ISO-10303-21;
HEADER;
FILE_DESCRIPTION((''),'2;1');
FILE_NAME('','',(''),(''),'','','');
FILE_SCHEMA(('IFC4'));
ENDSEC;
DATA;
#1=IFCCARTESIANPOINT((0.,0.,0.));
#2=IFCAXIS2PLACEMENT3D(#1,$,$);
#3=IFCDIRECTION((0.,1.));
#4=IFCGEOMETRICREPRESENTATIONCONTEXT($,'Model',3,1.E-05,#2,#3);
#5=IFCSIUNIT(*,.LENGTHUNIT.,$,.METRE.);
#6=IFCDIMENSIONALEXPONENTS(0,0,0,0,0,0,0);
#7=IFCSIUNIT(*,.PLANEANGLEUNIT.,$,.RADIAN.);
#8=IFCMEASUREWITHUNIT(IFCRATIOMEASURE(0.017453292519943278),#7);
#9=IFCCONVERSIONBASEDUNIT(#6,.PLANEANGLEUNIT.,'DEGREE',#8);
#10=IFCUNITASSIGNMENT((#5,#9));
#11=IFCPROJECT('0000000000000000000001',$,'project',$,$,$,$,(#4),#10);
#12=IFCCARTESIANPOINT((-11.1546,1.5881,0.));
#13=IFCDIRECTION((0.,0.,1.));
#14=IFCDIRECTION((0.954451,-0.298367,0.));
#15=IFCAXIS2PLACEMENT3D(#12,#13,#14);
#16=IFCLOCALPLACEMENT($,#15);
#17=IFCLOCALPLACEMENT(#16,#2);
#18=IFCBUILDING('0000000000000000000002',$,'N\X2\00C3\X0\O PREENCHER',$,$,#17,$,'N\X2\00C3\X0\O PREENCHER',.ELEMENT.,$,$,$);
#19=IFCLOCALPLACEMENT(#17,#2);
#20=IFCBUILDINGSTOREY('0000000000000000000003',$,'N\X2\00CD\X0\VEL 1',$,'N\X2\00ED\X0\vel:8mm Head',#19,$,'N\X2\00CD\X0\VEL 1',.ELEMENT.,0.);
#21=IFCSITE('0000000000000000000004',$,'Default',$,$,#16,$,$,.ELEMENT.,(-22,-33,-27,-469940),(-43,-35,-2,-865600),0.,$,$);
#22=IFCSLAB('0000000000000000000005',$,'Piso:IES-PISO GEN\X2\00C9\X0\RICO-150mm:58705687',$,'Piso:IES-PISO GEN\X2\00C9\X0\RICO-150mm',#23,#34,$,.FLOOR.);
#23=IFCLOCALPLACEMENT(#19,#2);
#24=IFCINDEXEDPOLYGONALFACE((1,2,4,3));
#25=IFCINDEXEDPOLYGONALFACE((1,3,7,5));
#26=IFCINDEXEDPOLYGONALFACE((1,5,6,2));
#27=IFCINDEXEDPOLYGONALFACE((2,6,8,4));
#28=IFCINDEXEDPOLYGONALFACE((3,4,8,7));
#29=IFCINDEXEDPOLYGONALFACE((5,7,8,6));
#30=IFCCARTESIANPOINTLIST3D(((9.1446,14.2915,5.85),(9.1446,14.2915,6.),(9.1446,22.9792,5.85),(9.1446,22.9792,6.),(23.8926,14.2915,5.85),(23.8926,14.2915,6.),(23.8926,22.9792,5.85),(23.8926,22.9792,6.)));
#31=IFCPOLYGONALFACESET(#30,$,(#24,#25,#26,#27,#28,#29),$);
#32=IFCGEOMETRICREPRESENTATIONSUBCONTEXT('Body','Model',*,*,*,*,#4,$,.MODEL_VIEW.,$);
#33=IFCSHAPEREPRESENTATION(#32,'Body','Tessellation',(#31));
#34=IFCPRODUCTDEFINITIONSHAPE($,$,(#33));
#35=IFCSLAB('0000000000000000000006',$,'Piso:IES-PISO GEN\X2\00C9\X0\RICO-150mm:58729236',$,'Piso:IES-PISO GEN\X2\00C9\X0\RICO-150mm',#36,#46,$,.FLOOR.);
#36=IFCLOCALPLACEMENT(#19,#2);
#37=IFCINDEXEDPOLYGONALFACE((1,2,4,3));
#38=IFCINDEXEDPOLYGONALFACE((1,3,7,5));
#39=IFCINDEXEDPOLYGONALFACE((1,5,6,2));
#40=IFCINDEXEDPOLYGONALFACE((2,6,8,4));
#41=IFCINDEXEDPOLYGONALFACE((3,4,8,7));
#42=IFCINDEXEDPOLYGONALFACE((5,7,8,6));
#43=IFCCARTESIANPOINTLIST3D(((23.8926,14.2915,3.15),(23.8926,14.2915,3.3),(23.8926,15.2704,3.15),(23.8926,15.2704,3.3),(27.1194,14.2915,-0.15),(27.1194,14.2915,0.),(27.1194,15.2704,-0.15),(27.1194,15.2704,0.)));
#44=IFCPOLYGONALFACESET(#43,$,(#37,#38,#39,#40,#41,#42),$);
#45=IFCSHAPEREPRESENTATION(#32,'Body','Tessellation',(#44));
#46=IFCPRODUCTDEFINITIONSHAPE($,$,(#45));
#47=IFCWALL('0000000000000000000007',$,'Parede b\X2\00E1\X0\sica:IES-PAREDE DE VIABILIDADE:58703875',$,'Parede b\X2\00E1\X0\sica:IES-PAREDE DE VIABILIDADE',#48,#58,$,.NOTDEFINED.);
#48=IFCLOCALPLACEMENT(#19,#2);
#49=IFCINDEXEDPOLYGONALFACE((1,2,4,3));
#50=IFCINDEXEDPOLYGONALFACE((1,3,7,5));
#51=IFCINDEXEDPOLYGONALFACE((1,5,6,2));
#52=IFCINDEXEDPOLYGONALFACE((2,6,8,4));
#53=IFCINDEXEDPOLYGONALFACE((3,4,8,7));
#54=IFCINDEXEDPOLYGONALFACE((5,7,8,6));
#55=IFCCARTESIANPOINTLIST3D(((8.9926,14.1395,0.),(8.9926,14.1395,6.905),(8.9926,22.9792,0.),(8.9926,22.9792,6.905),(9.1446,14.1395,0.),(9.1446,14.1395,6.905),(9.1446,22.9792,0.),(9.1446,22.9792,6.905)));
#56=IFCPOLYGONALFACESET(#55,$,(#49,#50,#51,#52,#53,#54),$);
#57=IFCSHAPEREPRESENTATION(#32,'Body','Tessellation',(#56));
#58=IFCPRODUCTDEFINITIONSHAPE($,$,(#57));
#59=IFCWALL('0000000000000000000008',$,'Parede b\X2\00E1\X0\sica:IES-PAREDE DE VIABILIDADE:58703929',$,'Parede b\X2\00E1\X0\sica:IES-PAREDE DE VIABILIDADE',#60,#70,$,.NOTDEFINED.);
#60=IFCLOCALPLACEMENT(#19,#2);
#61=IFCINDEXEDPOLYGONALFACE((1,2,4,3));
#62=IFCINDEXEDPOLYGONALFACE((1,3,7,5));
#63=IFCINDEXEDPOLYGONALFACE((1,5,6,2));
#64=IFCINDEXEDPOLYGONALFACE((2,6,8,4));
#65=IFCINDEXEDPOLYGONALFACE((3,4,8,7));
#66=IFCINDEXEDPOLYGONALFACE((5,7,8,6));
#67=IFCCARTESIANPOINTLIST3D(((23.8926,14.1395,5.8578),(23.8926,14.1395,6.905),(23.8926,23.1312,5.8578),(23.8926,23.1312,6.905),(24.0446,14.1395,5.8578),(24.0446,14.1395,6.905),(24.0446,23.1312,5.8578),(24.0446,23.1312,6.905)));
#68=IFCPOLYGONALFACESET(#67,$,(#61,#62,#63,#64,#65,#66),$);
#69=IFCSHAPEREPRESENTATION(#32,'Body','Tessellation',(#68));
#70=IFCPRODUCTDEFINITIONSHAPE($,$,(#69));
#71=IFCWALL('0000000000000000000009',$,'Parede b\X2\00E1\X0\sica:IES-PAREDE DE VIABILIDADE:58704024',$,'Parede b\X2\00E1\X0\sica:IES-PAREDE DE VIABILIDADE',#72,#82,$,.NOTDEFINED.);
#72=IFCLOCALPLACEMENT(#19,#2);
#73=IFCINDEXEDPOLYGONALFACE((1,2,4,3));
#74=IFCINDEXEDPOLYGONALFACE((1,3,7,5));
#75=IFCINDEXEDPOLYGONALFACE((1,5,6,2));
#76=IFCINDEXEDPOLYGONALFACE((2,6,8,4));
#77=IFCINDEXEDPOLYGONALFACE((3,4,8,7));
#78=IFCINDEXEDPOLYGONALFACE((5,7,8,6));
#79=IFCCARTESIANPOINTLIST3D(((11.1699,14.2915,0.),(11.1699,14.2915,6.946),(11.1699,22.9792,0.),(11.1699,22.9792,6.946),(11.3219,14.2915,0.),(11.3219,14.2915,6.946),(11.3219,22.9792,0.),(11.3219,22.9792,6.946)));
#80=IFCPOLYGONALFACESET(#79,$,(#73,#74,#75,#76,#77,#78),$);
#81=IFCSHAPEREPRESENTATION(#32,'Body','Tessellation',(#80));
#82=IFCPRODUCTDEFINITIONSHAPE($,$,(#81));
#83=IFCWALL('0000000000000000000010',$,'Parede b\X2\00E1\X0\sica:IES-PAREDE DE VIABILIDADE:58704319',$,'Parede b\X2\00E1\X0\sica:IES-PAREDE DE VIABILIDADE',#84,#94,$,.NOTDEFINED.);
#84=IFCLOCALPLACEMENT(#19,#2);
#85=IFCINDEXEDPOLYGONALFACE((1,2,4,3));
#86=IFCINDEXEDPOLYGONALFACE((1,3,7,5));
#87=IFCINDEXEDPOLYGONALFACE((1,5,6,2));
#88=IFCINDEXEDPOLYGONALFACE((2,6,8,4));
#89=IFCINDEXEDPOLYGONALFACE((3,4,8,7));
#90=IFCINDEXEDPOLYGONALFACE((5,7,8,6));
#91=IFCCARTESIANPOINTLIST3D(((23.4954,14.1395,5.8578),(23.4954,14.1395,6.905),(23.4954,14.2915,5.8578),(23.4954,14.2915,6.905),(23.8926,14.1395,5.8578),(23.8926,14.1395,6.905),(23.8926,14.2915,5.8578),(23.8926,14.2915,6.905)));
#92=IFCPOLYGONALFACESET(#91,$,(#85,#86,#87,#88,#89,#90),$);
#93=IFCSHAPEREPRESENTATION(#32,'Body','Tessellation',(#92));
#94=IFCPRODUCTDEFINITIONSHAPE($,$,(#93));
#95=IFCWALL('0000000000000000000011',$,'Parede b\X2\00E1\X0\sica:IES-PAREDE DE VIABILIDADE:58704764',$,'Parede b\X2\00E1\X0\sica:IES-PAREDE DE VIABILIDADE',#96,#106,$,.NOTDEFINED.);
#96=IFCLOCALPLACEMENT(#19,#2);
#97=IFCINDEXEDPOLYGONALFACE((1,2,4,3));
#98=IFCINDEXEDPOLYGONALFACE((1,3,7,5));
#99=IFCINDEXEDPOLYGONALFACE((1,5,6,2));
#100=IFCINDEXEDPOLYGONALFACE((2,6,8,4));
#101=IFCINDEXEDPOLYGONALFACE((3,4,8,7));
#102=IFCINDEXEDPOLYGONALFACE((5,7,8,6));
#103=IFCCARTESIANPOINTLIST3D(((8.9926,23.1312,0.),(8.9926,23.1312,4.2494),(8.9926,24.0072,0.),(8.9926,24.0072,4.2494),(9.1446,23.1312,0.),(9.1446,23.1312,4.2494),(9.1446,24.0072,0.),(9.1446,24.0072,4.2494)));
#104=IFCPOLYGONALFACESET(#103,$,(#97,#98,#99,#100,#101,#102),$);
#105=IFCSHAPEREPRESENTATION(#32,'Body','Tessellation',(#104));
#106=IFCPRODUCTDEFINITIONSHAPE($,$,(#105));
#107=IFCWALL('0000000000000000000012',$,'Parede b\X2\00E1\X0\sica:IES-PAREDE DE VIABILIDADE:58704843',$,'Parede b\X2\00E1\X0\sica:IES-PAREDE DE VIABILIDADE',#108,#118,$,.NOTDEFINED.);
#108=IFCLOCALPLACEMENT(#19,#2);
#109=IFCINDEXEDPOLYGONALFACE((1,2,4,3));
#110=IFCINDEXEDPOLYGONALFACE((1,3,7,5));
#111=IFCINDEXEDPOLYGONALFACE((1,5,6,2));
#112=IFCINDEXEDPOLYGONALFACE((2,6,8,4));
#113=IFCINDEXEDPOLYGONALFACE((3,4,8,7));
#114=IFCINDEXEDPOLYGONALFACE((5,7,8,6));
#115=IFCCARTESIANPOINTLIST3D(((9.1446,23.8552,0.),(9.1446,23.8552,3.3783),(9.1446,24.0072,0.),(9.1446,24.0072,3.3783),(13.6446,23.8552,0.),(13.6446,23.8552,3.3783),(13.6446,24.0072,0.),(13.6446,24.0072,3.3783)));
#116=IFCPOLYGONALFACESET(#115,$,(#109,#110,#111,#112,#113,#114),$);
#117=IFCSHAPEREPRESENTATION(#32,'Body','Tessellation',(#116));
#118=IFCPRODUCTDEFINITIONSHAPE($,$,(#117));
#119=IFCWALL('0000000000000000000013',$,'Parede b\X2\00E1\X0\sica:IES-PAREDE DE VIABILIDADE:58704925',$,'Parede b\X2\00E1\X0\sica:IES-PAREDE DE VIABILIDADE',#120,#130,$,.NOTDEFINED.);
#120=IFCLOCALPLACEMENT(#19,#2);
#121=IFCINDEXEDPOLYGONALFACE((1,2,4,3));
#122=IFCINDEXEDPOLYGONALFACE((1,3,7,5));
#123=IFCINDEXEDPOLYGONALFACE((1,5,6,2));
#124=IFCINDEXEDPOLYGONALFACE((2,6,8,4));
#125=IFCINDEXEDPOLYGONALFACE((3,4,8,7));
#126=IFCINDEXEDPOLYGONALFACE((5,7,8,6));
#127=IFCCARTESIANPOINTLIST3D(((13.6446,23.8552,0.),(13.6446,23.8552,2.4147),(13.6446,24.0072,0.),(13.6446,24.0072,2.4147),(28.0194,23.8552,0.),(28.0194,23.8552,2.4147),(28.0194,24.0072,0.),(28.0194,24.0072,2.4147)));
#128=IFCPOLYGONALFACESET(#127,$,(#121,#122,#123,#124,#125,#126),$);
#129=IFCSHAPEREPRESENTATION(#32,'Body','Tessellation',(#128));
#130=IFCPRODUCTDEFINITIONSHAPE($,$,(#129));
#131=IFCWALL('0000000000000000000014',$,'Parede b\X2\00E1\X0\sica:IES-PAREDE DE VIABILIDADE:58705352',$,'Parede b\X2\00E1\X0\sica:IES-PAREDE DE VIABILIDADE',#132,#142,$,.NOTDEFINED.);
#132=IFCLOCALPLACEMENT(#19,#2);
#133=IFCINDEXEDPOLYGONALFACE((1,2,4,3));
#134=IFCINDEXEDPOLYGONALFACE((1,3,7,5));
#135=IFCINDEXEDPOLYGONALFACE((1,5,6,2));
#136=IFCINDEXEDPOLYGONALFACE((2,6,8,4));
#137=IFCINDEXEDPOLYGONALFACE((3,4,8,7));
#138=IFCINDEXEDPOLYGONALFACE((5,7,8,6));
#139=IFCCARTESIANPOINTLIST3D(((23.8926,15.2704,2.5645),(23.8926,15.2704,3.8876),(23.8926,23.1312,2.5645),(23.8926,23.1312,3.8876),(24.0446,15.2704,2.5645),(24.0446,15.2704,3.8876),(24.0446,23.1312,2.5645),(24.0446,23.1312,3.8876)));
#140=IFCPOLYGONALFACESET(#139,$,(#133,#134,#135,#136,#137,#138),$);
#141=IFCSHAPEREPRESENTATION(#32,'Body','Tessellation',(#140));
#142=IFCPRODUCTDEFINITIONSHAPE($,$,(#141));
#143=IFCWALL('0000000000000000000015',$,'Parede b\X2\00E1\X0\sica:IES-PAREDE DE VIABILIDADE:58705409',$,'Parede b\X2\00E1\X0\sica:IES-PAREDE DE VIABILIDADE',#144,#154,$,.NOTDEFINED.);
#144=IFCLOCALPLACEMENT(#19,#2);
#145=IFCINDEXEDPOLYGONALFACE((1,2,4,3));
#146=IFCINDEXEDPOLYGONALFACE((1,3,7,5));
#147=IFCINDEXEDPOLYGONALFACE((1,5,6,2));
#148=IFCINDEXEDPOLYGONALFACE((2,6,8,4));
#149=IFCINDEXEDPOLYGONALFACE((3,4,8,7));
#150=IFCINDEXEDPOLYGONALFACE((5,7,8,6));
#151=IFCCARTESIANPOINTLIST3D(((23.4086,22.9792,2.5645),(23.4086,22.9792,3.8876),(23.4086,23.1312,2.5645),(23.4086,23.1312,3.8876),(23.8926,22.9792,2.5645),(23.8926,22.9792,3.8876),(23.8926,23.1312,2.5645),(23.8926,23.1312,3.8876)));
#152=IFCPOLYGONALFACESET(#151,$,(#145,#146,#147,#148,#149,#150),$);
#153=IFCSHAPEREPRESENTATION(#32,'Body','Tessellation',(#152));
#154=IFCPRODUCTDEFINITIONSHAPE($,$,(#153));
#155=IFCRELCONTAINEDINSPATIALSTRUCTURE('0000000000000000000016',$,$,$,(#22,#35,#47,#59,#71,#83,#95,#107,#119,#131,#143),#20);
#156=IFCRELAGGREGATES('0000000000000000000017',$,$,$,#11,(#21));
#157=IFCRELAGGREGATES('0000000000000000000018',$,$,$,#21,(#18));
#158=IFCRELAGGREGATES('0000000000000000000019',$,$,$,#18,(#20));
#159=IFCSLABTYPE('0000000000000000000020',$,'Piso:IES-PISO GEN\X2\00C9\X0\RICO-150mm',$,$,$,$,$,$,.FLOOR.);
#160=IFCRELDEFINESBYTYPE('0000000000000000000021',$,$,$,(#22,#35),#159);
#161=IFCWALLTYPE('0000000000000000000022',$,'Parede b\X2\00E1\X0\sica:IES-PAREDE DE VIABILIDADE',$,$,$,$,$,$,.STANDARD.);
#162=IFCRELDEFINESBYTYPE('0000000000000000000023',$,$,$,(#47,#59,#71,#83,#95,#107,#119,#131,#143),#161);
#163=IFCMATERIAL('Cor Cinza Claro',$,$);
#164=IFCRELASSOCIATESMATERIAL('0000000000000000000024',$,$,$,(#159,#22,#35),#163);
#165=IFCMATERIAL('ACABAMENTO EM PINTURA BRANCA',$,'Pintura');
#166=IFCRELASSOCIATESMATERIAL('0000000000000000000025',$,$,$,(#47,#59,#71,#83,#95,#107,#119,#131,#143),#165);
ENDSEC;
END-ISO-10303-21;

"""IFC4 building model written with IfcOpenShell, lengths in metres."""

from ifc_helpers import new_model, entity, si_unit, converted_unit, direction, frame, frame_2d, origin, place, context, subcontext, project, spatial, indexed_curve, rectangle, outline, extrude, material, type_object, element, save


model = new_model("IFC4")

# Units and contexts
model_context = context("Model", 3, precision=1e-05, world=origin(), true_north=direction((0.0, 1.0)))
body_context = subcontext(model_context, "Body", "Model", "MODEL_VIEW")
ifc_project = project(units=[si_unit("LENGTHUNIT", "METRE"), converted_unit("PLANEANGLEUNIT", "DEGREE", entity("IfcRatioMeasure", 0.017453292519943278), si_unit("PLANEANGLEUNIT", "RADIAN"), dimensions=[0, 0, 0, 0, 0, 0, 0])], contexts=[model_context])

# Site, building, storey
site_placement = place(None, frame((-11.1546, 1.5881, 0.0), z_axis=(0.0, 0.0, 1.0), x_axis=(0.954451, -0.298367, 0.0)))
site = spatial("IfcSite", under=ifc_project, at=site_placement, Name="Default", CompositionType="ELEMENT", RefLatitude=(-22, -33, -27, -469940), RefLongitude=(-43, -35, -2, -865600), RefElevation=0.0)
building_placement = place(site_placement, origin())
building = spatial("IfcBuilding", under=site, at=building_placement, Name="NÃO PREENCHER", LongName="NÃO PREENCHER", CompositionType="ELEMENT")
storey_placement = place(building_placement, origin())
storey = spatial("IfcBuildingStorey", under=building, at=storey_placement, Name="NÍVEL 1", ObjectType="Nível:8mm Head", LongName="NÍVEL 1", CompositionType="ELEMENT", Elevation=0.0)

# Slabs
ifc_material_1 = material(Name="Cor Cinza Claro")
slab_type = type_object("IfcSlabType", Name="Piso:IES-PISO GENÉRICO-150mm", PredefinedType="FLOOR", material=ifc_material_1)
slab_1_placement = place(storey_placement, origin())
element("IfcSlab", 1, at=slab_1_placement, inside=storey, type_object=slab_type, material=ifc_material_1, Name="Piso:IES-PISO GENÉRICO-150mm:58705687", ObjectType="Piso:IES-PISO GENÉRICO-150mm", PredefinedType="FLOOR", context=body_context, shape_type="SweptSolid", body=[
    extrude(outline(indexed_curve([(-4.3438, -7.374), (4.3438, -7.374), (4.3438, 7.374), (-4.3438, 7.374), (-4.3438, -7.374)], self_intersect=False)), frame((16.5186, 18.6353, 6.0), z_axis=(0.0, 0.0, -1.0), x_axis=(0.0, 1.0, 0.0)), (0.0, 0.0, 1.0), 0.15),
])
slab_2_placement = place(storey_placement, frame((23.8926, 14.2915, -0.15)))
element("IfcSlab", 2, at=slab_2_placement, inside=storey, type_object=slab_type, material=ifc_material_1, Name="Piso:IES-PISO GENÉRICO-150mm:58729236", ObjectType="Piso:IES-PISO GENÉRICO-150mm", PredefinedType="FLOOR", context=body_context, shape_type="SweptSolid", body=[
    extrude(rectangle(XDim=4.6155, YDim=0.9789, at=frame_2d((0.0, 0.0), x_axis=(-1.0, 0.0))), frame((1.6134, 0.4894, 1.8), z_axis=(0.714989, 0.0, 0.699135), x_axis=(0.699135, 0.0, -0.714989)), (0.714989, 0.0, -0.699135), 0.15),
])

# Walls
ifc_material_2 = material(Name="ACABAMENTO EM PINTURA BRANCA", Category="Pintura")
wall_type = type_object("IfcWallType", Name="Parede básica:IES-PAREDE DE VIABILIDADE", PredefinedType="STANDARD")
wall_1_placement = place(storey_placement, frame((9.0686, 14.1395, 0.0), z_axis=(0.0, 0.0, 1.0), x_axis=(0.0, 1.0, 0.0)))
element("IfcWall", 3, at=wall_1_placement, inside=storey, type_object=wall_type, material=ifc_material_2, Name="Parede básica:IES-PAREDE DE VIABILIDADE:58703875", ObjectType="Parede básica:IES-PAREDE DE VIABILIDADE", PredefinedType="NOTDEFINED", context=body_context, shape_type="SweptSolid", body=[
    extrude(outline(indexed_curve([(8.8397, 0.076), (0.0, 0.076), (0.0, -0.076), (8.8397, -0.076), (8.8397, 0.076)], self_intersect=False)), origin(), (0.0, 0.0, 1.0), 6.905),
])
wall_2_placement = place(storey_placement, frame((23.9686, 23.1312, 5.8578), z_axis=(0.0, 0.0, 1.0), x_axis=(0.0, -1.0, 0.0)))
element("IfcWall", 4, at=wall_2_placement, inside=storey, type_object=wall_type, material=ifc_material_2, Name="Parede básica:IES-PAREDE DE VIABILIDADE:58703929", ObjectType="Parede básica:IES-PAREDE DE VIABILIDADE", PredefinedType="NOTDEFINED", context=body_context, shape_type="SweptSolid", body=[
    extrude(outline(indexed_curve([(8.9917, 0.076), (0.0, 0.076), (0.0, -0.076), (8.9917, -0.076), (8.9917, 0.076)], self_intersect=False)), origin(), (0.0, 0.0, 1.0), 1.0472),
])
wall_3_placement = place(storey_placement, frame((11.2459, 22.9792, 0.0), z_axis=(0.0, 0.0, 1.0), x_axis=(0.0, -1.0, 0.0)))
element("IfcWall", 5, at=wall_3_placement, inside=storey, type_object=wall_type, material=ifc_material_2, Name="Parede básica:IES-PAREDE DE VIABILIDADE:58704024", ObjectType="Parede básica:IES-PAREDE DE VIABILIDADE", PredefinedType="NOTDEFINED", context=body_context, shape_type="SweptSolid", body=[
    extrude(outline(indexed_curve([(8.6877, 0.076), (0.0, 0.076), (0.0, -0.076), (8.6877, -0.076), (8.6877, 0.076)], self_intersect=False)), origin(), (0.0, 0.0, 1.0), 6.946),
])
wall_4_placement = place(storey_placement, frame((23.8926, 14.2155, 5.8578), z_axis=(0.0, 0.0, 1.0), x_axis=(-1.0, 0.0, 0.0)))
element("IfcWall", 6, at=wall_4_placement, inside=storey, type_object=wall_type, material=ifc_material_2, Name="Parede básica:IES-PAREDE DE VIABILIDADE:58704319", ObjectType="Parede básica:IES-PAREDE DE VIABILIDADE", PredefinedType="NOTDEFINED", context=body_context, shape_type="SweptSolid", body=[
    extrude(outline(indexed_curve([(0.3972, 0.076), (0.0, 0.076), (0.0, -0.076), (0.3972, -0.076), (0.3972, 0.076)], self_intersect=False)), origin(), (0.0, 0.0, 1.0), 1.0472),
])
wall_5_placement = place(storey_placement, frame((9.0686, 23.1312, 0.0), z_axis=(0.0, 0.0, 1.0), x_axis=(0.0, 1.0, 0.0)))
element("IfcWall", 7, at=wall_5_placement, inside=storey, type_object=wall_type, material=ifc_material_2, Name="Parede básica:IES-PAREDE DE VIABILIDADE:58704764", ObjectType="Parede básica:IES-PAREDE DE VIABILIDADE", PredefinedType="NOTDEFINED", context=body_context, shape_type="SweptSolid", body=[
    extrude(outline(indexed_curve([(0.876, 0.076), (0.0, 0.076), (0.0, -0.076), (0.876, -0.076), (0.876, 0.076)], self_intersect=False)), origin(), (0.0, 0.0, 1.0), 4.2494),
])
wall_6_placement = place(storey_placement, frame((9.1446, 23.9312, 0.0)))
element("IfcWall", 8, at=wall_6_placement, inside=storey, type_object=wall_type, material=ifc_material_2, Name="Parede básica:IES-PAREDE DE VIABILIDADE:58704843", ObjectType="Parede básica:IES-PAREDE DE VIABILIDADE", PredefinedType="NOTDEFINED", context=body_context, shape_type="SweptSolid", body=[
    extrude(outline(indexed_curve([(4.5, 0.076), (0.0, 0.076), (0.0, -0.076), (4.5, -0.076), (4.5, 0.076)], self_intersect=False)), origin(), (0.0, 0.0, 1.0), 3.3783),
])
wall_7_placement = place(storey_placement, frame((13.6446, 23.9312, 0.0)))
element("IfcWall", 9, at=wall_7_placement, inside=storey, type_object=wall_type, material=ifc_material_2, Name="Parede básica:IES-PAREDE DE VIABILIDADE:58704925", ObjectType="Parede básica:IES-PAREDE DE VIABILIDADE", PredefinedType="NOTDEFINED", context=body_context, shape_type="SweptSolid", body=[
    extrude(outline(indexed_curve([(14.3748, 0.076), (0.0, 0.076), (0.0, -0.076), (14.3748, -0.076), (14.3748, 0.076)], self_intersect=False)), origin(), (0.0, 0.0, 1.0), 2.4147),
])
wall_8_placement = place(storey_placement, frame((23.9686, 23.1312, 2.5645), z_axis=(0.0, 0.0, 1.0), x_axis=(0.0, -1.0, 0.0)))
element("IfcWall", 10, at=wall_8_placement, inside=storey, type_object=wall_type, material=ifc_material_2, Name="Parede básica:IES-PAREDE DE VIABILIDADE:58705352", ObjectType="Parede básica:IES-PAREDE DE VIABILIDADE", PredefinedType="NOTDEFINED", context=body_context, shape_type="SweptSolid", body=[
    extrude(outline(indexed_curve([(7.8608, 0.076), (0.0, 0.076), (0.0, -0.076), (7.8608, -0.076), (7.8608, 0.076)], self_intersect=False)), origin(), (0.0, 0.0, 1.0), 1.3231),
])
wall_9_placement = place(storey_placement, frame((23.4086, 23.0552, 2.5645)))
element("IfcWall", 11, at=wall_9_placement, inside=storey, type_object=wall_type, material=ifc_material_2, Name="Parede básica:IES-PAREDE DE VIABILIDADE:58705409", ObjectType="Parede básica:IES-PAREDE DE VIABILIDADE", PredefinedType="NOTDEFINED", context=body_context, shape_type="SweptSolid", body=[
    extrude(outline(indexed_curve([(0.484, 0.076), (0.0, 0.076), (0.0, -0.076), (0.484, -0.076), (0.484, 0.076)], self_intersect=False)), origin(), (0.0, 0.0, 1.0), 1.3231),
])

save(model, "model.ifc")
